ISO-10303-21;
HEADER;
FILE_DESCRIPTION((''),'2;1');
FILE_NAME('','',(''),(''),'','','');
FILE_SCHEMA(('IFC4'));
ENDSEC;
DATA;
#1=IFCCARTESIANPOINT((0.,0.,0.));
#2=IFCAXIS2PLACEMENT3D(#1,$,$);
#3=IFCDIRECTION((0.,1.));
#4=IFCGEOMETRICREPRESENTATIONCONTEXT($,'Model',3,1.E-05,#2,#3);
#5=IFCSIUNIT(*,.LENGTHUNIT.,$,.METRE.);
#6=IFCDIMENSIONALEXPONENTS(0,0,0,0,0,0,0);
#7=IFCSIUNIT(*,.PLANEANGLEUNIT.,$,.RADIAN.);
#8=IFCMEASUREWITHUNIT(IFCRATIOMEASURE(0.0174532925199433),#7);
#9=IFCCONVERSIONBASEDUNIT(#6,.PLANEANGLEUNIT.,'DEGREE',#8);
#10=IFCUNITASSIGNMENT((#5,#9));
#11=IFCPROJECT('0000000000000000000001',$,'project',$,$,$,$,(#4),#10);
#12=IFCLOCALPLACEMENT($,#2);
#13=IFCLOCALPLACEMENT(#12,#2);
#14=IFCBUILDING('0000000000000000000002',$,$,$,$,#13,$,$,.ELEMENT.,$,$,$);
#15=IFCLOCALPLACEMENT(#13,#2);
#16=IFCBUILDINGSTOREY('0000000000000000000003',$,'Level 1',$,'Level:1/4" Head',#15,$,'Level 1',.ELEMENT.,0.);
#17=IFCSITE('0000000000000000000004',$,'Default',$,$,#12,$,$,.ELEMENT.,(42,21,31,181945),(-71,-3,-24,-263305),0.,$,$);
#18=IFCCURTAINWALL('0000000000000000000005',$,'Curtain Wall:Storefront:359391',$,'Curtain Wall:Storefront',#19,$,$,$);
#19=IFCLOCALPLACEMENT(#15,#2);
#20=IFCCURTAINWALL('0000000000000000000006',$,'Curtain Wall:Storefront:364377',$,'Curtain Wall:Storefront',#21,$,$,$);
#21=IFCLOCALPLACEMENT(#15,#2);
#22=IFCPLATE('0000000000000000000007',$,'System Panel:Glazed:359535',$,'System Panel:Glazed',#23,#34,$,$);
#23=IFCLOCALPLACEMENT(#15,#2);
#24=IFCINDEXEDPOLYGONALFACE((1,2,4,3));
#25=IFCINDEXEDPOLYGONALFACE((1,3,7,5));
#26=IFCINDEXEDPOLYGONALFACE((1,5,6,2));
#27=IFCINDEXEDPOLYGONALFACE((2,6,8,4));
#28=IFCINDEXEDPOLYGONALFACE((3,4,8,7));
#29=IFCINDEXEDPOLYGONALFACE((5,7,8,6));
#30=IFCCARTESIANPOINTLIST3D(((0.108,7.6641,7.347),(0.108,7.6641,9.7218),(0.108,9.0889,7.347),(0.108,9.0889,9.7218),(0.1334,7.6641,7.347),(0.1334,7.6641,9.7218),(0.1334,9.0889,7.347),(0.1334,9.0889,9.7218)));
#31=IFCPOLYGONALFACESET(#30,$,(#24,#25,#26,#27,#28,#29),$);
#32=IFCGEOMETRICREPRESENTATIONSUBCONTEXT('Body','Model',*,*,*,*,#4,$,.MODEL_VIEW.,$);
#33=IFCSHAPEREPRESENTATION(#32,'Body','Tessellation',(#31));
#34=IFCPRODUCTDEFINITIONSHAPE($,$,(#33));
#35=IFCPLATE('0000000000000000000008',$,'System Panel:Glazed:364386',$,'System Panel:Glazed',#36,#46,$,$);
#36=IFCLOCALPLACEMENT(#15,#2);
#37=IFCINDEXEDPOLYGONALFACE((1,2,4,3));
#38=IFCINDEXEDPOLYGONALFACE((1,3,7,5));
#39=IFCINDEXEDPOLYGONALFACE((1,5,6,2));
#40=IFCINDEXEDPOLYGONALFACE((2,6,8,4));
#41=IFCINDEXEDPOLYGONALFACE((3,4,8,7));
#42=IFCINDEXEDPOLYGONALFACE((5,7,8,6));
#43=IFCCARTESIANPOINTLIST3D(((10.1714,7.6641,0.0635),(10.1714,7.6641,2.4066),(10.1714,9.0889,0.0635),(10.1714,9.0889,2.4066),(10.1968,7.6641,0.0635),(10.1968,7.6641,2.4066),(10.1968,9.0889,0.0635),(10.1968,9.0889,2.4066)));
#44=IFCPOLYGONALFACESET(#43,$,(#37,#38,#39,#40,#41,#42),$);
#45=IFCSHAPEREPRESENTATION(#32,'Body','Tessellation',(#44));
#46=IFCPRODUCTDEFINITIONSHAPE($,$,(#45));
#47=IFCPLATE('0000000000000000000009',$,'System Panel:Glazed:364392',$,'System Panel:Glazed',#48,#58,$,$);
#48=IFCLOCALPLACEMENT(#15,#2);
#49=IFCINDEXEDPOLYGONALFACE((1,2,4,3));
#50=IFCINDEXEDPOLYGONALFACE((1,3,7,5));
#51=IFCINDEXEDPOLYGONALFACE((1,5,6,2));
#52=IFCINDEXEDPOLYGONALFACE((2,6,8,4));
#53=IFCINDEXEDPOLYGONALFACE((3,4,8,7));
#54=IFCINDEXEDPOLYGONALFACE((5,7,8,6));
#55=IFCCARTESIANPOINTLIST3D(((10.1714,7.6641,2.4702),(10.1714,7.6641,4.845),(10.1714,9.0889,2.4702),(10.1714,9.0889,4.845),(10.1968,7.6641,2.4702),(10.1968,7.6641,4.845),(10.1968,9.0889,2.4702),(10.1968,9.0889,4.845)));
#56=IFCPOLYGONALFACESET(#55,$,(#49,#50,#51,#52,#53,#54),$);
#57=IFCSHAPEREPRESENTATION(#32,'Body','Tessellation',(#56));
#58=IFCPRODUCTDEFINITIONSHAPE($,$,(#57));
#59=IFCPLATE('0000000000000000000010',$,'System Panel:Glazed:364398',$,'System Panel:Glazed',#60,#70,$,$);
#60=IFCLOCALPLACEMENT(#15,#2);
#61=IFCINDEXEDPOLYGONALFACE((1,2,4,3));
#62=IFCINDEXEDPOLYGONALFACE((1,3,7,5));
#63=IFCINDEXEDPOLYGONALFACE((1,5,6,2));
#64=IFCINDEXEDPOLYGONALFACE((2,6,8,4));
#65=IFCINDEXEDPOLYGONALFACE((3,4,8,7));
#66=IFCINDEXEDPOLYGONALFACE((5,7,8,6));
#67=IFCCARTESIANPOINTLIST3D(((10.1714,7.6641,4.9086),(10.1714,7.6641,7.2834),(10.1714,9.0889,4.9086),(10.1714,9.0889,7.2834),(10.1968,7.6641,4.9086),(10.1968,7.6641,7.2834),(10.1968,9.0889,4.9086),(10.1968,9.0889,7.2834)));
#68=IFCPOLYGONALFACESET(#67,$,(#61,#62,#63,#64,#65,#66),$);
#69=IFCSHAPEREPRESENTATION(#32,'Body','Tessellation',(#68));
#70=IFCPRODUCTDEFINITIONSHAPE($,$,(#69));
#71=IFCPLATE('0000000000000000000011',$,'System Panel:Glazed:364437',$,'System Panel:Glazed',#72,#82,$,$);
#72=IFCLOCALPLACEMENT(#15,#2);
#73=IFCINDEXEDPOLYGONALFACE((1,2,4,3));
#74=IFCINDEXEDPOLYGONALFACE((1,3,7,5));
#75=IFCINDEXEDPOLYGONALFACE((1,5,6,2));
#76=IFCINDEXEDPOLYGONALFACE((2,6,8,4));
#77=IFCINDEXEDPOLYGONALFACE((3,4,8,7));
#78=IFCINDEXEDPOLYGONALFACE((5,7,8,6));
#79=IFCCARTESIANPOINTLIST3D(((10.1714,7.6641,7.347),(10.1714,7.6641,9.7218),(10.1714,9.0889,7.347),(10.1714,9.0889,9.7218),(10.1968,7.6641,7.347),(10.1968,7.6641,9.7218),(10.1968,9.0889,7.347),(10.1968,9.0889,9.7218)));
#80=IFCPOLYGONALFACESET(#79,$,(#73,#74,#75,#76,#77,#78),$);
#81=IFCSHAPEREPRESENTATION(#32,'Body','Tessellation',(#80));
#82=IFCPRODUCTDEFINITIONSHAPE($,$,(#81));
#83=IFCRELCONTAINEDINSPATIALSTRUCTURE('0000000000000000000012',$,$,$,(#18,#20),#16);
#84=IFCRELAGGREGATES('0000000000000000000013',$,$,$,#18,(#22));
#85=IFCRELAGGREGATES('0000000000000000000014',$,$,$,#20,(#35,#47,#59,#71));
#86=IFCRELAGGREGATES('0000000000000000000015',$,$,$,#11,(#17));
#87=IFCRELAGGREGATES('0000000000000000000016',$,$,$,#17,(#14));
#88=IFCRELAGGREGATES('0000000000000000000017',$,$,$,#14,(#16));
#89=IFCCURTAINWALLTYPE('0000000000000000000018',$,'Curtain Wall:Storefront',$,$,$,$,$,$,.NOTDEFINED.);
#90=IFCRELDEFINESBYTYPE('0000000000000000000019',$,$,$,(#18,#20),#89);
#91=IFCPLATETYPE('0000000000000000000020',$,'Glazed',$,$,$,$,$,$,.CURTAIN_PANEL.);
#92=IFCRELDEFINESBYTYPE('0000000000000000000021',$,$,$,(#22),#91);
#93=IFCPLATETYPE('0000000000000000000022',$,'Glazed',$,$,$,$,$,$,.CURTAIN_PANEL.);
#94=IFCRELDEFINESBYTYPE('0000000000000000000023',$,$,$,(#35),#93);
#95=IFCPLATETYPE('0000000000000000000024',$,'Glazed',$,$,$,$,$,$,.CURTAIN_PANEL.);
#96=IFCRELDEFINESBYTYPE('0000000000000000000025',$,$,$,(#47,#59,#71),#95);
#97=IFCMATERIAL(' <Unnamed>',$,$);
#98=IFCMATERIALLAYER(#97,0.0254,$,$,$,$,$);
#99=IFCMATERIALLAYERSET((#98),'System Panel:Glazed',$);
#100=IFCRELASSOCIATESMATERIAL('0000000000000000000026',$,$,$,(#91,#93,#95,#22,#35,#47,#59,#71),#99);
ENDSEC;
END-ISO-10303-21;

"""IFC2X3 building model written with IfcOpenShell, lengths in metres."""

from ifc_helpers import new_model, entity, si_unit, converted_unit, direction, frame, frame_2d, origin, place, context, subcontext, project, spatial, rectangle, extrude, source, transform, mapped, material, layer, layer_set, layer_usage, type_object, type_shapes, element, aggregate, save


model = new_model("IFC2X3")

# Units and contexts
model_context = context("Model", 3, precision=1e-05, world=origin(), true_north=direction((0.0, 1.0)))
body_context = subcontext(model_context, "Body", "Model", "MODEL_VIEW")
ifc_project = project(units=[si_unit("LENGTHUNIT", "METRE"), converted_unit("PLANEANGLEUNIT", "DEGREE", entity("IfcRatioMeasure", 0.0174532925199433), si_unit("PLANEANGLEUNIT", "RADIAN"), dimensions=[0, 0, 0, 0, 0, 0, 0])], contexts=[model_context])

# Site, building, storey
site_placement = place(None, origin())
site = spatial("IfcSite", under=ifc_project, at=site_placement, Name="Default", CompositionType="ELEMENT", RefLatitude=(42, 21, 31, 181945), RefLongitude=(-71, -3, -24, -263305), RefElevation=0.0)
building_placement = place(site_placement, origin())
building = spatial("IfcBuilding", under=site, at=building_placement, CompositionType="ELEMENT")
storey_placement = place(building_placement, origin())
storey = spatial("IfcBuildingStorey", under=building, at=storey_placement, Name="Level 1", ObjectType="Level:1/4\" Head", LongName="Level 1", CompositionType="ELEMENT", Elevation=0.0)

# Curtain walls
curtain_wall_type = type_object("IfcCurtainWallType", Name="Curtain Wall:Storefront", PredefinedType="NOTDEFINED")
curtain_wall_1_placement = place(storey_placement, origin())
curtain_wall_1 = element("IfcCurtainWall", 1, at=curtain_wall_1_placement, inside=storey, type_object=curtain_wall_type, Name="Curtain Wall:Storefront:359391", ObjectType="Curtain Wall:Storefront")
curtain_wall_2_placement = place(storey_placement, origin())
curtain_wall_2 = element("IfcCurtainWall", 2, at=curtain_wall_2_placement, inside=storey, type_object=curtain_wall_type, Name="Curtain Wall:Storefront:364377", ObjectType="Curtain Wall:Storefront")

# Plates
ifc_material_1 = material(Name=" <Unnamed>")
ifc_layer = layer(ifc_material_1, 0.0254)
ifc_layer_set = layer_set([ifc_layer], Name="System Panel:Glazed")
plate_type_1 = type_object("IfcPlateType", Name="Glazed", PredefinedType="CURTAIN_PANEL", material=ifc_layer_set)
shared_shape_1 = source(origin(), body_context, "Body", "SweptSolid", [
    extrude(rectangle(XDim=0.0254, YDim=1.4248, at=frame_2d((0.0, 0.0), x_axis=(1.0, 0.0))), frame((0.7124, 0.0127, 0.0), z_axis=(0.0, 0.0, 1.0), x_axis=(0.0, 1.0, 0.0)), (0.0, 0.0, 1.0), 2.3749),
])
type_shapes(plate_type_1, [shared_shape_1])
ifc_layer_usage_1 = layer_usage(ifc_layer_set, "AXIS3", "POSITIVE", 0.1042)
plate_1_placement = place(curtain_wall_1_placement, frame((0.1334, 7.6641, 7.3469), z_axis=(0.0, 0.0, 1.0), x_axis=(0.0, 1.0, 0.0)))
plate_1 = element("IfcPlate", 3, at=plate_1_placement, type_object=plate_type_1, material=ifc_layer_usage_1, Name="System Panel:Glazed:359535", ObjectType="System Panel:Glazed", context=body_context, shape_type="MappedRepresentation", body=[
    mapped(shared_shape_1, transform((0.0, 0.0, 0.0), scale=1.0)),
])
aggregate(curtain_wall_1, [plate_1])
ifc_layer_usage_2 = layer_usage(ifc_layer_set, "AXIS3", "POSITIVE", 0.1042)
plate_type_2 = type_object("IfcPlateType", Name="Glazed", PredefinedType="CURTAIN_PANEL", material=ifc_layer_set)
shared_shape_2 = source(origin(), body_context, "Body", "SweptSolid", [
    extrude(rectangle(XDim=0.0254, YDim=1.4248, at=frame_2d((0.0, 0.0), x_axis=(1.0, 0.0))), frame((0.7124, 0.0127, 0.0), z_axis=(0.0, 0.0, 1.0), x_axis=(0.0, 1.0, 0.0)), (0.0, 0.0, 1.0), 2.3432),
])
type_shapes(plate_type_2, [shared_shape_2])
plate_2_placement = place(curtain_wall_2_placement, frame((10.1968, 7.6641, 0.0635), z_axis=(0.0, 0.0, 1.0), x_axis=(0.0, 1.0, 0.0)))
plate_2 = element("IfcPlate", 4, at=plate_2_placement, type_object=plate_type_2, material=ifc_layer_usage_2, Name="System Panel:Glazed:364386", ObjectType="System Panel:Glazed", context=body_context, shape_type="MappedRepresentation", body=[
    mapped(shared_shape_2, transform((0.0, 0.0, 0.0), scale=1.0)),
])
ifc_layer_usage_3 = layer_usage(ifc_layer_set, "AXIS3", "POSITIVE", 0.1042)
plate_type_3 = type_object("IfcPlateType", Name="Glazed", PredefinedType="CURTAIN_PANEL", material=ifc_layer_set)
shared_shape_3 = source(origin(), body_context, "Body", "SweptSolid", [
    extrude(rectangle(XDim=0.0254, YDim=1.4248, at=frame_2d((0.0, 0.0), x_axis=(1.0, 0.0))), frame((0.7124, 0.0127, 0.0), z_axis=(0.0, 0.0, 1.0), x_axis=(0.0, 1.0, 0.0)), (0.0, 0.0, 1.0), 2.3749),
])
type_shapes(plate_type_3, [shared_shape_3])
plate_3_placement = place(curtain_wall_2_placement, frame((10.1968, 7.6641, 2.4701), z_axis=(0.0, 0.0, 1.0), x_axis=(0.0, 1.0, 0.0)))
plate_3 = element("IfcPlate", 5, at=plate_3_placement, type_object=plate_type_3, material=ifc_layer_usage_3, Name="System Panel:Glazed:364392", ObjectType="System Panel:Glazed", context=body_context, shape_type="MappedRepresentation", body=[
    mapped(shared_shape_3, transform((0.0, 0.0, 0.0), scale=1.0)),
])
ifc_layer_usage_4 = layer_usage(ifc_layer_set, "AXIS3", "POSITIVE", 0.1042)
plate_4_placement = place(curtain_wall_2_placement, frame((10.1968, 7.6641, 4.9085), z_axis=(0.0, 0.0, 1.0), x_axis=(0.0, 1.0, 0.0)))
plate_4 = element("IfcPlate", 6, at=plate_4_placement, type_object=plate_type_3, material=ifc_layer_usage_4, Name="System Panel:Glazed:364398", ObjectType="System Panel:Glazed", context=body_context, shape_type="MappedRepresentation", body=[
    mapped(shared_shape_3, transform((0.0, 0.0, 0.0), scale=1.0)),
])
ifc_layer_usage_5 = layer_usage(ifc_layer_set, "AXIS3", "POSITIVE", 0.1042)
plate_5_placement = place(curtain_wall_2_placement, frame((10.1968, 7.6641, 7.3469), z_axis=(0.0, 0.0, 1.0), x_axis=(0.0, 1.0, 0.0)))
plate_5 = element("IfcPlate", 7, at=plate_5_placement, type_object=plate_type_3, material=ifc_layer_usage_5, Name="System Panel:Glazed:364437", ObjectType="System Panel:Glazed", context=body_context, shape_type="MappedRepresentation", body=[
    mapped(shared_shape_3, transform((0.0, 0.0, 0.0), scale=1.0)),
])
aggregate(curtain_wall_2, [plate_2, plate_3, plate_4, plate_5])

save(model, "model.ifc")
